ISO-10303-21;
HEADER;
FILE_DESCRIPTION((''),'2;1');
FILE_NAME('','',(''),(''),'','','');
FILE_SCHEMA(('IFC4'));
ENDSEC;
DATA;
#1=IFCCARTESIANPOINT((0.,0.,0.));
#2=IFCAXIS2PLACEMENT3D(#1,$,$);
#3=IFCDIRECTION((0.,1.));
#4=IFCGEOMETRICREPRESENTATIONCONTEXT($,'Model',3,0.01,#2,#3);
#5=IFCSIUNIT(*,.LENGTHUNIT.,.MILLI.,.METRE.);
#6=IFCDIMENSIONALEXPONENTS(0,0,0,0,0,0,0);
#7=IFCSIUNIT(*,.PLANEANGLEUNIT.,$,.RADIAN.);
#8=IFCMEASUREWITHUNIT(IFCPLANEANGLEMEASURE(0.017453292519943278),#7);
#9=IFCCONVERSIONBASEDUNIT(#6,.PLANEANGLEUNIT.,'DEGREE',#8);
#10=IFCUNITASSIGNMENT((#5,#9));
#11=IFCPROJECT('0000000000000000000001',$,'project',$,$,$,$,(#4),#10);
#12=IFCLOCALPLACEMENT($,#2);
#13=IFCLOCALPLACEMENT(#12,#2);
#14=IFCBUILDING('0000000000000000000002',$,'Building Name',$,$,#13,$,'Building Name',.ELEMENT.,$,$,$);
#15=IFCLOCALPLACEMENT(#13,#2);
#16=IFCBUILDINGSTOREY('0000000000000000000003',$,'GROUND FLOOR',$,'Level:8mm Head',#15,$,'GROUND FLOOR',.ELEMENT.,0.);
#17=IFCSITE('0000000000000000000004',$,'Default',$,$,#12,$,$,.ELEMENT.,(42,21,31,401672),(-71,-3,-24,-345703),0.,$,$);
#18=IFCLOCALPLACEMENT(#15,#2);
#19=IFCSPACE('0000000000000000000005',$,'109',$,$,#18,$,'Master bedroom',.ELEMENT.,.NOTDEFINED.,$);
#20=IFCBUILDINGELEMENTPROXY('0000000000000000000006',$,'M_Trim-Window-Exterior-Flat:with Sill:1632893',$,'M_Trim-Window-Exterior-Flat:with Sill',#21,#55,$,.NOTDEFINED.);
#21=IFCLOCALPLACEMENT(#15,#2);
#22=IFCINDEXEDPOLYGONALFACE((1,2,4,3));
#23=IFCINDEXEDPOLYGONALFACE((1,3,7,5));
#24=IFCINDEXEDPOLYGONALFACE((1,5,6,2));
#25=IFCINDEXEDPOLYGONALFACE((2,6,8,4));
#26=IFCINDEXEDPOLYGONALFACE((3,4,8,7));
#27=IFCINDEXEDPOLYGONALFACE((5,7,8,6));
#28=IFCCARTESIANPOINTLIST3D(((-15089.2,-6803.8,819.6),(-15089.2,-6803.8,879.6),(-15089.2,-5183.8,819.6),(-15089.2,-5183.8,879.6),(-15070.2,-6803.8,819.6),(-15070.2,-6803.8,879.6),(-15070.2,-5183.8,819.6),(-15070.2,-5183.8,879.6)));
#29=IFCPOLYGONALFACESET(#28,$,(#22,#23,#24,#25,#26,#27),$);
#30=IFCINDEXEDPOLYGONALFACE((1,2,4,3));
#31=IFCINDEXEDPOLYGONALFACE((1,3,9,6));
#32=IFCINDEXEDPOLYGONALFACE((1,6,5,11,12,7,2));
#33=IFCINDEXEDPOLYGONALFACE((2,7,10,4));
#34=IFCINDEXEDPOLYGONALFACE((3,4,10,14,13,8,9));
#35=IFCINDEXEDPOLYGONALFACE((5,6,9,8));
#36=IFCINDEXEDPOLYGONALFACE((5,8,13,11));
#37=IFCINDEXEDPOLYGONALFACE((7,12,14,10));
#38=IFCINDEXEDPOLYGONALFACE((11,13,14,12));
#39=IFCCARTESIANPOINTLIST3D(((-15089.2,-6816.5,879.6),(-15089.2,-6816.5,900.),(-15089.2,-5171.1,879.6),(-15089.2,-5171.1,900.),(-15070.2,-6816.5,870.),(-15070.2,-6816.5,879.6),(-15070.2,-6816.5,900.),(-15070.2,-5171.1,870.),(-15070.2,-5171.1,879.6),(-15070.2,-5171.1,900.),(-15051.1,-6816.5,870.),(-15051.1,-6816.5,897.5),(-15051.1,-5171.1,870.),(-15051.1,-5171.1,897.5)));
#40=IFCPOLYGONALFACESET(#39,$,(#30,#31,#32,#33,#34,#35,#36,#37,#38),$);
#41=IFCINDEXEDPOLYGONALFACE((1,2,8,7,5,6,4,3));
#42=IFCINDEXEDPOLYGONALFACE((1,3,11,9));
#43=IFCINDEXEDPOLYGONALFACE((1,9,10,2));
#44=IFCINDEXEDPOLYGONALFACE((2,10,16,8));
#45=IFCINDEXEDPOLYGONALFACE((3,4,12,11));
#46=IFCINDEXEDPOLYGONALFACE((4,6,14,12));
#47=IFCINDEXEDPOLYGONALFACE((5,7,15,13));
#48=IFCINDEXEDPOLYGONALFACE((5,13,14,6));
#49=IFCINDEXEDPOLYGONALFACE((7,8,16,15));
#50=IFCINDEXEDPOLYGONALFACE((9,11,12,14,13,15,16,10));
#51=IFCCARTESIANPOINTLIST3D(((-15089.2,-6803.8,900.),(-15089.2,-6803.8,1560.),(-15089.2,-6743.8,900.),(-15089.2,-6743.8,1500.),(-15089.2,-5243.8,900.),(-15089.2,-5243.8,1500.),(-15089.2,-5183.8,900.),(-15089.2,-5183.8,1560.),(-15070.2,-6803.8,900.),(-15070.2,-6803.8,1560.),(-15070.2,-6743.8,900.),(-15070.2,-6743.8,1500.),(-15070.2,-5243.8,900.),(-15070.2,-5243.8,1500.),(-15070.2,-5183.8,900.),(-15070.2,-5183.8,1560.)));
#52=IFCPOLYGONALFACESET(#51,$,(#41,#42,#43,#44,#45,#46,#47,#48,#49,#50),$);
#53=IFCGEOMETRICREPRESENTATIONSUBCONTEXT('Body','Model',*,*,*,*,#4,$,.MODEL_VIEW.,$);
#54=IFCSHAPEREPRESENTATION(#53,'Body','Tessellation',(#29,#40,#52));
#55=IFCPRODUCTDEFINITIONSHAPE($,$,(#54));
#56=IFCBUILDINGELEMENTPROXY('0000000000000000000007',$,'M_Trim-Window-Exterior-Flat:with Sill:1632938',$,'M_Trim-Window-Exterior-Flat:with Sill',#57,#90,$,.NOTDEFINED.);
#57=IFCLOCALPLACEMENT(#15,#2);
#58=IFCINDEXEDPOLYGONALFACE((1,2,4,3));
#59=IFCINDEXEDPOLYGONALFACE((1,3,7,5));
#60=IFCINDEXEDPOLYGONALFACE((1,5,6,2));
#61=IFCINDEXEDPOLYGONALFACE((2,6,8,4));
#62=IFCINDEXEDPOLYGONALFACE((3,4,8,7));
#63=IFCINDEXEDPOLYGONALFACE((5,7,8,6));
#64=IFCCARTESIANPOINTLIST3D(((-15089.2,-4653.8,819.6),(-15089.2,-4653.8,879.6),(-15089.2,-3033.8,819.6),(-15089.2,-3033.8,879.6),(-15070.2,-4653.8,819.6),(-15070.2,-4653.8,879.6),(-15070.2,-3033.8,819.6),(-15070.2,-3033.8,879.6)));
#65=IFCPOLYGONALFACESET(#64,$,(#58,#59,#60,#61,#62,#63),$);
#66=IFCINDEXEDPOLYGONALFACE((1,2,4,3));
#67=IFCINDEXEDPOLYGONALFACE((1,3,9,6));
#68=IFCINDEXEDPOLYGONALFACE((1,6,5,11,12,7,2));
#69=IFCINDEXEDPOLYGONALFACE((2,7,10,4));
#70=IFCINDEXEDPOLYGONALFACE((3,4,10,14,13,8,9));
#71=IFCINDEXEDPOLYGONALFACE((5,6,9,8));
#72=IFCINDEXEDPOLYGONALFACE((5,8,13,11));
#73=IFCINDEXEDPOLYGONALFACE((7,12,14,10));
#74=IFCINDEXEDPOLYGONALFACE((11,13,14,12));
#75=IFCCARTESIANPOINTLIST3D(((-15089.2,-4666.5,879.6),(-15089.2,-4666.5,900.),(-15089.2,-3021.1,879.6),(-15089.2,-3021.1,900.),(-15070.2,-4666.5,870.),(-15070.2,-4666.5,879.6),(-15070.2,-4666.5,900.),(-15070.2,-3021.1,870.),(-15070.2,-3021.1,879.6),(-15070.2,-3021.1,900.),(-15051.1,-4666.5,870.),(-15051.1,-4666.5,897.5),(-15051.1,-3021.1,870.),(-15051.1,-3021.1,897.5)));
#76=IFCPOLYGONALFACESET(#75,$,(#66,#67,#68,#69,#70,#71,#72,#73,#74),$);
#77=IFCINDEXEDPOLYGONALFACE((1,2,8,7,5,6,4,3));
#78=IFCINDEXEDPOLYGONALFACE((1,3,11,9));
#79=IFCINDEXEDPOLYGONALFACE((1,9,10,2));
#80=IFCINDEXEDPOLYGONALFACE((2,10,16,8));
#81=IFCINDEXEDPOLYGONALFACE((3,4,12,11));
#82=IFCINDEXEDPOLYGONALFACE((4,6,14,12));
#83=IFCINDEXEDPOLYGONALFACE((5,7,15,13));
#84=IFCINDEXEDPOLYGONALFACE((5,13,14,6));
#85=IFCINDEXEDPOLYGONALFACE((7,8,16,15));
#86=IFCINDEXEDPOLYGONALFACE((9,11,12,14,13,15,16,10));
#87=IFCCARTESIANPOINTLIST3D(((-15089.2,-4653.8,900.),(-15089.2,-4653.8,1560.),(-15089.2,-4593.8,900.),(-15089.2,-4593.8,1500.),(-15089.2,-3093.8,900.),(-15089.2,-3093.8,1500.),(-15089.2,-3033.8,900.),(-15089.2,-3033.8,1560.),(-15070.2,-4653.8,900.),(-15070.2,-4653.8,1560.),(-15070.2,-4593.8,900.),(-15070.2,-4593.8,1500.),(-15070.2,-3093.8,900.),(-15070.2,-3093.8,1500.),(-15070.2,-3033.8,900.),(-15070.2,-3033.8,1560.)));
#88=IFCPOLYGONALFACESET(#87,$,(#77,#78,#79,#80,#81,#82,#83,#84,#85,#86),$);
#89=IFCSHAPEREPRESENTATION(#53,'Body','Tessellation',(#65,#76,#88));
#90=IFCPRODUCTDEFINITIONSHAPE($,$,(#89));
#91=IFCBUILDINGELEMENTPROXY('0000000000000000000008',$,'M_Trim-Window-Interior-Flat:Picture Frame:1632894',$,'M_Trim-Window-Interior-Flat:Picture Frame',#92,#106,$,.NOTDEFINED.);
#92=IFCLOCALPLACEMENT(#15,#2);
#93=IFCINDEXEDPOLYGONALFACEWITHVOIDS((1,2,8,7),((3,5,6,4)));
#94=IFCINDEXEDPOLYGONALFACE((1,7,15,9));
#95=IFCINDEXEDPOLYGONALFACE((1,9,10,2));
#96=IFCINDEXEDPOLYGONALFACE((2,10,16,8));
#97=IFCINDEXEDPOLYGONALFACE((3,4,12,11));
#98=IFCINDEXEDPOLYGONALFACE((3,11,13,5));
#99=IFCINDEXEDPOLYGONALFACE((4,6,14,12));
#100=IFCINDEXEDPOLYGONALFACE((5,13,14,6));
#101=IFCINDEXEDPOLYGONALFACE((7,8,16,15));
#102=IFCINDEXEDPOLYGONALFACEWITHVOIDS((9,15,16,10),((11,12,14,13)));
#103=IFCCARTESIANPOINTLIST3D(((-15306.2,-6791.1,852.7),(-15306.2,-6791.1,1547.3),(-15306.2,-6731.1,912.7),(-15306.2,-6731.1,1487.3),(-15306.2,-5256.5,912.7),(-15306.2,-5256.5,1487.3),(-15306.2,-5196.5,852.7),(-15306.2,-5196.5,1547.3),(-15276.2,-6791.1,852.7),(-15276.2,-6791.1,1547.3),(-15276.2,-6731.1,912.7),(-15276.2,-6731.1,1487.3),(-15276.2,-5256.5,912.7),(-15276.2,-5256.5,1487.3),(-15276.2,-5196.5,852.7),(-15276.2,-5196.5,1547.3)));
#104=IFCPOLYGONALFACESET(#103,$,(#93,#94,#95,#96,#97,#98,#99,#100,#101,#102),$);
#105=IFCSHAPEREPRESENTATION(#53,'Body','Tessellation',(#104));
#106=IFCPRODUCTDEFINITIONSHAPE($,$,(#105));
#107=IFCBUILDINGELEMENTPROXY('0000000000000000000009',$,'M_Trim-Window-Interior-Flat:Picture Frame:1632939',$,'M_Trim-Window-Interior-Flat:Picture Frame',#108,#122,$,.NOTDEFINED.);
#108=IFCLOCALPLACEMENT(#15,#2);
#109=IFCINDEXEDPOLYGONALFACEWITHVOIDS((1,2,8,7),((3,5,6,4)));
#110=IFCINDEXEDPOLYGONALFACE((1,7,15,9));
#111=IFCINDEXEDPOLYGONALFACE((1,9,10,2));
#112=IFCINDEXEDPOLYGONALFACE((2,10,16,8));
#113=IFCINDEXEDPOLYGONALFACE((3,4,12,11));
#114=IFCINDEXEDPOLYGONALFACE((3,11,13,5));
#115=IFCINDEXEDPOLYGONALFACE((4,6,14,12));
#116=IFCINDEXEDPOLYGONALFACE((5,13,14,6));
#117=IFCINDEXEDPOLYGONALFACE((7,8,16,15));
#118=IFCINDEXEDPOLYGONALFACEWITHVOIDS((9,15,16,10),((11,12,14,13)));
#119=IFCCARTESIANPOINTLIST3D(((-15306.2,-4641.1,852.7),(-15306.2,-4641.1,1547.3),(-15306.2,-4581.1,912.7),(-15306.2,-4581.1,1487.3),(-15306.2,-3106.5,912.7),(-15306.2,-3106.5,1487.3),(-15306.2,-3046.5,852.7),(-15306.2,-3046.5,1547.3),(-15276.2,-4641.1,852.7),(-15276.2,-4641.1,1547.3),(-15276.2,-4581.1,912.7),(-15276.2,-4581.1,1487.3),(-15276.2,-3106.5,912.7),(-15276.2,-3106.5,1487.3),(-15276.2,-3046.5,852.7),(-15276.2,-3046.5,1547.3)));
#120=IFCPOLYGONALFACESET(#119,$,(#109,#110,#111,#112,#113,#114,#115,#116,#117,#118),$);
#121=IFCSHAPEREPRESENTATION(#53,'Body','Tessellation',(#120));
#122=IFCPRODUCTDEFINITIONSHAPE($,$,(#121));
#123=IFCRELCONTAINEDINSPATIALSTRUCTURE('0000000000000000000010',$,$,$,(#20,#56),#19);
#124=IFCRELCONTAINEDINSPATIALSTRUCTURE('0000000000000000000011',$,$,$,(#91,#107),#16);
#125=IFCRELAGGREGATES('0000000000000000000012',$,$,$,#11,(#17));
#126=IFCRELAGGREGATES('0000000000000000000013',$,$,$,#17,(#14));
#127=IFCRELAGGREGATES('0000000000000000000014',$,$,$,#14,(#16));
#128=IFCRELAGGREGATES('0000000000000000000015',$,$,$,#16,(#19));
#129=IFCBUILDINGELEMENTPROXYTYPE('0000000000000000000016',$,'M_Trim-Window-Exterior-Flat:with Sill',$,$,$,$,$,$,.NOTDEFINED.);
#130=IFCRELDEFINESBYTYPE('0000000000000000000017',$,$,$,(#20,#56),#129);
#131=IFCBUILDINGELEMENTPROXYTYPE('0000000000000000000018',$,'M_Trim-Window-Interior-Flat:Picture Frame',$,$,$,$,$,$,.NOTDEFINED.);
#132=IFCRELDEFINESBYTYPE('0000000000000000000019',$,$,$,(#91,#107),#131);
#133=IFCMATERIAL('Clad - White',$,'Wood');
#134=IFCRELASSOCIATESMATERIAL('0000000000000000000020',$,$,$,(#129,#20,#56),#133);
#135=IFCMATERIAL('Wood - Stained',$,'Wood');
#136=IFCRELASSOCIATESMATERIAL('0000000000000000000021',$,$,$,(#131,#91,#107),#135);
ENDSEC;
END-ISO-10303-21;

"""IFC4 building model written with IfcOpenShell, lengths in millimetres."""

from ifc_helpers import new_model, entity, si_unit, converted_unit, direction, frame, origin, place, context, subcontext, project, spatial, indexed_curve, outline, extrude, source, transform, mapped, material, type_object, type_shapes, element, save


model = new_model("IFC4")

# Units and contexts
model_context = context("Model", 3, precision=0.01, world=origin(), true_north=direction((0.0, 1.0)))
body_context = subcontext(model_context, "Body", "Model", "MODEL_VIEW")
ifc_project = project(units=[si_unit("LENGTHUNIT", "METRE", prefix="MILLI"), converted_unit("PLANEANGLEUNIT", "DEGREE", entity("IfcPlaneAngleMeasure", 0.017453292519943278), si_unit("PLANEANGLEUNIT", "RADIAN"), dimensions=[0, 0, 0, 0, 0, 0, 0])], contexts=[model_context])

# Site, building, storey
site_placement = place(None, origin())
site = spatial("IfcSite", under=ifc_project, at=site_placement, Name="Default", CompositionType="ELEMENT", RefLatitude=(42, 21, 31, 401672), RefLongitude=(-71, -3, -24, -345703), RefElevation=0.0)
building_placement = place(site_placement, origin())
building = spatial("IfcBuilding", under=site, at=building_placement, Name="Building Name", LongName="Building Name", CompositionType="ELEMENT")
storey_placement = place(building_placement, origin())
storey = spatial("IfcBuildingStorey", under=building, at=storey_placement, Name="GROUND FLOOR", ObjectType="Level:8mm Head", LongName="GROUND FLOOR", CompositionType="ELEMENT", Elevation=0.0)

# Shared definitions
ifc_material_1 = material(Name="Wood - Stained", Category="Wood")

# Shared definitions
space_1_placement = place(storey_placement, origin())
space_1 = spatial("IfcSpace", under=storey, at=space_1_placement, Name="109", LongName="Master bedroom", CompositionType="ELEMENT", PredefinedType="NOTDEFINED")

# Building element proxies
ifc_material_2 = material(Name="Clad - White", Category="Wood")
building_element_proxy_type_1 = type_object("IfcBuildingElementProxyType", Name="M_Trim-Window-Exterior-Flat:with Sill", PredefinedType="NOTDEFINED", material=ifc_material_2)
shared_shape_1 = source(origin(), body_context, "Body", "SweptSolid", [
    extrude(outline(indexed_curve([(-810.0, -30.0), (810.0, -30.0), (810.0, 30.0), (-810.0, 30.0), (-810.0, -30.0)], self_intersect=False)), frame((0.0, -650.4, 0.0), z_axis=(0.0, 0.0, 1.0), x_axis=(-1.0, 0.0, 0.0)), (0.0, 0.0, 1.0), 19.0),
    extrude(outline(indexed_curve([(-19.0, -15.2), (0.0, -15.2), (0.0, -5.7), (19.0, -5.7), (19.0, 14.8), (0.0, 14.8), (-19.0, 12.3), (-19.0, -15.2)], self_intersect=False)), frame((-822.7, -614.8, 19.0), z_axis=(1.0, 0.0, 0.0), x_axis=(0.0, 0.0, -1.0)), (0.0, 0.0, 1.0), 1645.4),
    extrude(outline(indexed_curve([(-345.0, -810.0), (315.0, -810.0), (315.0, -750.0), (-285.0, -750.0), (-285.0, 750.0), (315.0, 750.0), (315.0, 810.0), (-345.0, 810.0), (-345.0, -810.0)], self_intersect=False)), frame((0.0, -285.0, 0.0), z_axis=(0.0, 0.0, 1.0), x_axis=(0.0, -1.0, 0.0)), (0.0, 0.0, 1.0), 19.0),
])
type_shapes(building_element_proxy_type_1, [shared_shape_1])
for number, where, z_axis, x_axis, name in (
    (1, (-15089.2, -5993.8, 1500.0), (1.0, 0.0, 0.0), (0.0, 1.0, 0.0), "M_Trim-Window-Exterior-Flat:with Sill:1632893"),
    (2, (-15089.2, -3843.8, 1500.0), (1.0, 0.0, 0.0), (0.0, 1.0, 0.0), "M_Trim-Window-Exterior-Flat:with Sill:1632938"),
):
    element("IfcBuildingElementProxy", number, at=place(space_1_placement, frame(where, z_axis=z_axis, x_axis=x_axis)), inside=space_1, type_object=building_element_proxy_type_1, material=ifc_material_2, Name=name, ObjectType="M_Trim-Window-Exterior-Flat:with Sill", PredefinedType="NOTDEFINED", context=body_context, shape_type="MappedRepresentation", body=[
        mapped(shared_shape_1, transform((0.0, 0.0, 0.0), scale=1.0)),
    ])
building_element_proxy_type_2 = type_object("IfcBuildingElementProxyType", Name="M_Trim-Window-Interior-Flat:Picture Frame", PredefinedType="NOTDEFINED", material=ifc_material_1)
shared_shape_2 = source(origin(), body_context, "Body", "SweptSolid", [
    extrude(outline(indexed_curve([(-797.3, -347.3), (797.3, -347.3), (797.3, 347.3), (-797.3, 347.3), (-797.3, -347.3)], self_intersect=False), holes=[indexed_curve([(-737.3, -287.3), (-737.3, 287.3), (737.3, 287.3), (737.3, -287.3), (-737.3, -287.3)], self_intersect=False)]), frame((0.0, -300.0, 0.0), z_axis=(0.0, 0.0, 1.0), x_axis=(-1.0, 0.0, 0.0)), (0.0, 0.0, 1.0), 30.0),
])
type_shapes(building_element_proxy_type_2, [shared_shape_2])
for number, where, z_axis, x_axis, name in (
    (3, (-15276.2, -5993.8, 1500.0), (-1.0, 0.0, 0.0), (0.0, -1.0, 0.0), "M_Trim-Window-Interior-Flat:Picture Frame:1632894"),
    (4, (-15276.2, -3843.8, 1500.0), (-1.0, 0.0, 0.0), (0.0, -1.0, 0.0), "M_Trim-Window-Interior-Flat:Picture Frame:1632939"),
):
    element("IfcBuildingElementProxy", number, at=place(storey_placement, frame(where, z_axis=z_axis, x_axis=x_axis)), inside=storey, type_object=building_element_proxy_type_2, material=ifc_material_1, Name=name, ObjectType="M_Trim-Window-Interior-Flat:Picture Frame", PredefinedType="NOTDEFINED", context=body_context, shape_type="MappedRepresentation", body=[
        mapped(shared_shape_2, transform((0.0, 0.0, 0.0), scale=1.0)),
    ])

save(model, "model.ifc")
